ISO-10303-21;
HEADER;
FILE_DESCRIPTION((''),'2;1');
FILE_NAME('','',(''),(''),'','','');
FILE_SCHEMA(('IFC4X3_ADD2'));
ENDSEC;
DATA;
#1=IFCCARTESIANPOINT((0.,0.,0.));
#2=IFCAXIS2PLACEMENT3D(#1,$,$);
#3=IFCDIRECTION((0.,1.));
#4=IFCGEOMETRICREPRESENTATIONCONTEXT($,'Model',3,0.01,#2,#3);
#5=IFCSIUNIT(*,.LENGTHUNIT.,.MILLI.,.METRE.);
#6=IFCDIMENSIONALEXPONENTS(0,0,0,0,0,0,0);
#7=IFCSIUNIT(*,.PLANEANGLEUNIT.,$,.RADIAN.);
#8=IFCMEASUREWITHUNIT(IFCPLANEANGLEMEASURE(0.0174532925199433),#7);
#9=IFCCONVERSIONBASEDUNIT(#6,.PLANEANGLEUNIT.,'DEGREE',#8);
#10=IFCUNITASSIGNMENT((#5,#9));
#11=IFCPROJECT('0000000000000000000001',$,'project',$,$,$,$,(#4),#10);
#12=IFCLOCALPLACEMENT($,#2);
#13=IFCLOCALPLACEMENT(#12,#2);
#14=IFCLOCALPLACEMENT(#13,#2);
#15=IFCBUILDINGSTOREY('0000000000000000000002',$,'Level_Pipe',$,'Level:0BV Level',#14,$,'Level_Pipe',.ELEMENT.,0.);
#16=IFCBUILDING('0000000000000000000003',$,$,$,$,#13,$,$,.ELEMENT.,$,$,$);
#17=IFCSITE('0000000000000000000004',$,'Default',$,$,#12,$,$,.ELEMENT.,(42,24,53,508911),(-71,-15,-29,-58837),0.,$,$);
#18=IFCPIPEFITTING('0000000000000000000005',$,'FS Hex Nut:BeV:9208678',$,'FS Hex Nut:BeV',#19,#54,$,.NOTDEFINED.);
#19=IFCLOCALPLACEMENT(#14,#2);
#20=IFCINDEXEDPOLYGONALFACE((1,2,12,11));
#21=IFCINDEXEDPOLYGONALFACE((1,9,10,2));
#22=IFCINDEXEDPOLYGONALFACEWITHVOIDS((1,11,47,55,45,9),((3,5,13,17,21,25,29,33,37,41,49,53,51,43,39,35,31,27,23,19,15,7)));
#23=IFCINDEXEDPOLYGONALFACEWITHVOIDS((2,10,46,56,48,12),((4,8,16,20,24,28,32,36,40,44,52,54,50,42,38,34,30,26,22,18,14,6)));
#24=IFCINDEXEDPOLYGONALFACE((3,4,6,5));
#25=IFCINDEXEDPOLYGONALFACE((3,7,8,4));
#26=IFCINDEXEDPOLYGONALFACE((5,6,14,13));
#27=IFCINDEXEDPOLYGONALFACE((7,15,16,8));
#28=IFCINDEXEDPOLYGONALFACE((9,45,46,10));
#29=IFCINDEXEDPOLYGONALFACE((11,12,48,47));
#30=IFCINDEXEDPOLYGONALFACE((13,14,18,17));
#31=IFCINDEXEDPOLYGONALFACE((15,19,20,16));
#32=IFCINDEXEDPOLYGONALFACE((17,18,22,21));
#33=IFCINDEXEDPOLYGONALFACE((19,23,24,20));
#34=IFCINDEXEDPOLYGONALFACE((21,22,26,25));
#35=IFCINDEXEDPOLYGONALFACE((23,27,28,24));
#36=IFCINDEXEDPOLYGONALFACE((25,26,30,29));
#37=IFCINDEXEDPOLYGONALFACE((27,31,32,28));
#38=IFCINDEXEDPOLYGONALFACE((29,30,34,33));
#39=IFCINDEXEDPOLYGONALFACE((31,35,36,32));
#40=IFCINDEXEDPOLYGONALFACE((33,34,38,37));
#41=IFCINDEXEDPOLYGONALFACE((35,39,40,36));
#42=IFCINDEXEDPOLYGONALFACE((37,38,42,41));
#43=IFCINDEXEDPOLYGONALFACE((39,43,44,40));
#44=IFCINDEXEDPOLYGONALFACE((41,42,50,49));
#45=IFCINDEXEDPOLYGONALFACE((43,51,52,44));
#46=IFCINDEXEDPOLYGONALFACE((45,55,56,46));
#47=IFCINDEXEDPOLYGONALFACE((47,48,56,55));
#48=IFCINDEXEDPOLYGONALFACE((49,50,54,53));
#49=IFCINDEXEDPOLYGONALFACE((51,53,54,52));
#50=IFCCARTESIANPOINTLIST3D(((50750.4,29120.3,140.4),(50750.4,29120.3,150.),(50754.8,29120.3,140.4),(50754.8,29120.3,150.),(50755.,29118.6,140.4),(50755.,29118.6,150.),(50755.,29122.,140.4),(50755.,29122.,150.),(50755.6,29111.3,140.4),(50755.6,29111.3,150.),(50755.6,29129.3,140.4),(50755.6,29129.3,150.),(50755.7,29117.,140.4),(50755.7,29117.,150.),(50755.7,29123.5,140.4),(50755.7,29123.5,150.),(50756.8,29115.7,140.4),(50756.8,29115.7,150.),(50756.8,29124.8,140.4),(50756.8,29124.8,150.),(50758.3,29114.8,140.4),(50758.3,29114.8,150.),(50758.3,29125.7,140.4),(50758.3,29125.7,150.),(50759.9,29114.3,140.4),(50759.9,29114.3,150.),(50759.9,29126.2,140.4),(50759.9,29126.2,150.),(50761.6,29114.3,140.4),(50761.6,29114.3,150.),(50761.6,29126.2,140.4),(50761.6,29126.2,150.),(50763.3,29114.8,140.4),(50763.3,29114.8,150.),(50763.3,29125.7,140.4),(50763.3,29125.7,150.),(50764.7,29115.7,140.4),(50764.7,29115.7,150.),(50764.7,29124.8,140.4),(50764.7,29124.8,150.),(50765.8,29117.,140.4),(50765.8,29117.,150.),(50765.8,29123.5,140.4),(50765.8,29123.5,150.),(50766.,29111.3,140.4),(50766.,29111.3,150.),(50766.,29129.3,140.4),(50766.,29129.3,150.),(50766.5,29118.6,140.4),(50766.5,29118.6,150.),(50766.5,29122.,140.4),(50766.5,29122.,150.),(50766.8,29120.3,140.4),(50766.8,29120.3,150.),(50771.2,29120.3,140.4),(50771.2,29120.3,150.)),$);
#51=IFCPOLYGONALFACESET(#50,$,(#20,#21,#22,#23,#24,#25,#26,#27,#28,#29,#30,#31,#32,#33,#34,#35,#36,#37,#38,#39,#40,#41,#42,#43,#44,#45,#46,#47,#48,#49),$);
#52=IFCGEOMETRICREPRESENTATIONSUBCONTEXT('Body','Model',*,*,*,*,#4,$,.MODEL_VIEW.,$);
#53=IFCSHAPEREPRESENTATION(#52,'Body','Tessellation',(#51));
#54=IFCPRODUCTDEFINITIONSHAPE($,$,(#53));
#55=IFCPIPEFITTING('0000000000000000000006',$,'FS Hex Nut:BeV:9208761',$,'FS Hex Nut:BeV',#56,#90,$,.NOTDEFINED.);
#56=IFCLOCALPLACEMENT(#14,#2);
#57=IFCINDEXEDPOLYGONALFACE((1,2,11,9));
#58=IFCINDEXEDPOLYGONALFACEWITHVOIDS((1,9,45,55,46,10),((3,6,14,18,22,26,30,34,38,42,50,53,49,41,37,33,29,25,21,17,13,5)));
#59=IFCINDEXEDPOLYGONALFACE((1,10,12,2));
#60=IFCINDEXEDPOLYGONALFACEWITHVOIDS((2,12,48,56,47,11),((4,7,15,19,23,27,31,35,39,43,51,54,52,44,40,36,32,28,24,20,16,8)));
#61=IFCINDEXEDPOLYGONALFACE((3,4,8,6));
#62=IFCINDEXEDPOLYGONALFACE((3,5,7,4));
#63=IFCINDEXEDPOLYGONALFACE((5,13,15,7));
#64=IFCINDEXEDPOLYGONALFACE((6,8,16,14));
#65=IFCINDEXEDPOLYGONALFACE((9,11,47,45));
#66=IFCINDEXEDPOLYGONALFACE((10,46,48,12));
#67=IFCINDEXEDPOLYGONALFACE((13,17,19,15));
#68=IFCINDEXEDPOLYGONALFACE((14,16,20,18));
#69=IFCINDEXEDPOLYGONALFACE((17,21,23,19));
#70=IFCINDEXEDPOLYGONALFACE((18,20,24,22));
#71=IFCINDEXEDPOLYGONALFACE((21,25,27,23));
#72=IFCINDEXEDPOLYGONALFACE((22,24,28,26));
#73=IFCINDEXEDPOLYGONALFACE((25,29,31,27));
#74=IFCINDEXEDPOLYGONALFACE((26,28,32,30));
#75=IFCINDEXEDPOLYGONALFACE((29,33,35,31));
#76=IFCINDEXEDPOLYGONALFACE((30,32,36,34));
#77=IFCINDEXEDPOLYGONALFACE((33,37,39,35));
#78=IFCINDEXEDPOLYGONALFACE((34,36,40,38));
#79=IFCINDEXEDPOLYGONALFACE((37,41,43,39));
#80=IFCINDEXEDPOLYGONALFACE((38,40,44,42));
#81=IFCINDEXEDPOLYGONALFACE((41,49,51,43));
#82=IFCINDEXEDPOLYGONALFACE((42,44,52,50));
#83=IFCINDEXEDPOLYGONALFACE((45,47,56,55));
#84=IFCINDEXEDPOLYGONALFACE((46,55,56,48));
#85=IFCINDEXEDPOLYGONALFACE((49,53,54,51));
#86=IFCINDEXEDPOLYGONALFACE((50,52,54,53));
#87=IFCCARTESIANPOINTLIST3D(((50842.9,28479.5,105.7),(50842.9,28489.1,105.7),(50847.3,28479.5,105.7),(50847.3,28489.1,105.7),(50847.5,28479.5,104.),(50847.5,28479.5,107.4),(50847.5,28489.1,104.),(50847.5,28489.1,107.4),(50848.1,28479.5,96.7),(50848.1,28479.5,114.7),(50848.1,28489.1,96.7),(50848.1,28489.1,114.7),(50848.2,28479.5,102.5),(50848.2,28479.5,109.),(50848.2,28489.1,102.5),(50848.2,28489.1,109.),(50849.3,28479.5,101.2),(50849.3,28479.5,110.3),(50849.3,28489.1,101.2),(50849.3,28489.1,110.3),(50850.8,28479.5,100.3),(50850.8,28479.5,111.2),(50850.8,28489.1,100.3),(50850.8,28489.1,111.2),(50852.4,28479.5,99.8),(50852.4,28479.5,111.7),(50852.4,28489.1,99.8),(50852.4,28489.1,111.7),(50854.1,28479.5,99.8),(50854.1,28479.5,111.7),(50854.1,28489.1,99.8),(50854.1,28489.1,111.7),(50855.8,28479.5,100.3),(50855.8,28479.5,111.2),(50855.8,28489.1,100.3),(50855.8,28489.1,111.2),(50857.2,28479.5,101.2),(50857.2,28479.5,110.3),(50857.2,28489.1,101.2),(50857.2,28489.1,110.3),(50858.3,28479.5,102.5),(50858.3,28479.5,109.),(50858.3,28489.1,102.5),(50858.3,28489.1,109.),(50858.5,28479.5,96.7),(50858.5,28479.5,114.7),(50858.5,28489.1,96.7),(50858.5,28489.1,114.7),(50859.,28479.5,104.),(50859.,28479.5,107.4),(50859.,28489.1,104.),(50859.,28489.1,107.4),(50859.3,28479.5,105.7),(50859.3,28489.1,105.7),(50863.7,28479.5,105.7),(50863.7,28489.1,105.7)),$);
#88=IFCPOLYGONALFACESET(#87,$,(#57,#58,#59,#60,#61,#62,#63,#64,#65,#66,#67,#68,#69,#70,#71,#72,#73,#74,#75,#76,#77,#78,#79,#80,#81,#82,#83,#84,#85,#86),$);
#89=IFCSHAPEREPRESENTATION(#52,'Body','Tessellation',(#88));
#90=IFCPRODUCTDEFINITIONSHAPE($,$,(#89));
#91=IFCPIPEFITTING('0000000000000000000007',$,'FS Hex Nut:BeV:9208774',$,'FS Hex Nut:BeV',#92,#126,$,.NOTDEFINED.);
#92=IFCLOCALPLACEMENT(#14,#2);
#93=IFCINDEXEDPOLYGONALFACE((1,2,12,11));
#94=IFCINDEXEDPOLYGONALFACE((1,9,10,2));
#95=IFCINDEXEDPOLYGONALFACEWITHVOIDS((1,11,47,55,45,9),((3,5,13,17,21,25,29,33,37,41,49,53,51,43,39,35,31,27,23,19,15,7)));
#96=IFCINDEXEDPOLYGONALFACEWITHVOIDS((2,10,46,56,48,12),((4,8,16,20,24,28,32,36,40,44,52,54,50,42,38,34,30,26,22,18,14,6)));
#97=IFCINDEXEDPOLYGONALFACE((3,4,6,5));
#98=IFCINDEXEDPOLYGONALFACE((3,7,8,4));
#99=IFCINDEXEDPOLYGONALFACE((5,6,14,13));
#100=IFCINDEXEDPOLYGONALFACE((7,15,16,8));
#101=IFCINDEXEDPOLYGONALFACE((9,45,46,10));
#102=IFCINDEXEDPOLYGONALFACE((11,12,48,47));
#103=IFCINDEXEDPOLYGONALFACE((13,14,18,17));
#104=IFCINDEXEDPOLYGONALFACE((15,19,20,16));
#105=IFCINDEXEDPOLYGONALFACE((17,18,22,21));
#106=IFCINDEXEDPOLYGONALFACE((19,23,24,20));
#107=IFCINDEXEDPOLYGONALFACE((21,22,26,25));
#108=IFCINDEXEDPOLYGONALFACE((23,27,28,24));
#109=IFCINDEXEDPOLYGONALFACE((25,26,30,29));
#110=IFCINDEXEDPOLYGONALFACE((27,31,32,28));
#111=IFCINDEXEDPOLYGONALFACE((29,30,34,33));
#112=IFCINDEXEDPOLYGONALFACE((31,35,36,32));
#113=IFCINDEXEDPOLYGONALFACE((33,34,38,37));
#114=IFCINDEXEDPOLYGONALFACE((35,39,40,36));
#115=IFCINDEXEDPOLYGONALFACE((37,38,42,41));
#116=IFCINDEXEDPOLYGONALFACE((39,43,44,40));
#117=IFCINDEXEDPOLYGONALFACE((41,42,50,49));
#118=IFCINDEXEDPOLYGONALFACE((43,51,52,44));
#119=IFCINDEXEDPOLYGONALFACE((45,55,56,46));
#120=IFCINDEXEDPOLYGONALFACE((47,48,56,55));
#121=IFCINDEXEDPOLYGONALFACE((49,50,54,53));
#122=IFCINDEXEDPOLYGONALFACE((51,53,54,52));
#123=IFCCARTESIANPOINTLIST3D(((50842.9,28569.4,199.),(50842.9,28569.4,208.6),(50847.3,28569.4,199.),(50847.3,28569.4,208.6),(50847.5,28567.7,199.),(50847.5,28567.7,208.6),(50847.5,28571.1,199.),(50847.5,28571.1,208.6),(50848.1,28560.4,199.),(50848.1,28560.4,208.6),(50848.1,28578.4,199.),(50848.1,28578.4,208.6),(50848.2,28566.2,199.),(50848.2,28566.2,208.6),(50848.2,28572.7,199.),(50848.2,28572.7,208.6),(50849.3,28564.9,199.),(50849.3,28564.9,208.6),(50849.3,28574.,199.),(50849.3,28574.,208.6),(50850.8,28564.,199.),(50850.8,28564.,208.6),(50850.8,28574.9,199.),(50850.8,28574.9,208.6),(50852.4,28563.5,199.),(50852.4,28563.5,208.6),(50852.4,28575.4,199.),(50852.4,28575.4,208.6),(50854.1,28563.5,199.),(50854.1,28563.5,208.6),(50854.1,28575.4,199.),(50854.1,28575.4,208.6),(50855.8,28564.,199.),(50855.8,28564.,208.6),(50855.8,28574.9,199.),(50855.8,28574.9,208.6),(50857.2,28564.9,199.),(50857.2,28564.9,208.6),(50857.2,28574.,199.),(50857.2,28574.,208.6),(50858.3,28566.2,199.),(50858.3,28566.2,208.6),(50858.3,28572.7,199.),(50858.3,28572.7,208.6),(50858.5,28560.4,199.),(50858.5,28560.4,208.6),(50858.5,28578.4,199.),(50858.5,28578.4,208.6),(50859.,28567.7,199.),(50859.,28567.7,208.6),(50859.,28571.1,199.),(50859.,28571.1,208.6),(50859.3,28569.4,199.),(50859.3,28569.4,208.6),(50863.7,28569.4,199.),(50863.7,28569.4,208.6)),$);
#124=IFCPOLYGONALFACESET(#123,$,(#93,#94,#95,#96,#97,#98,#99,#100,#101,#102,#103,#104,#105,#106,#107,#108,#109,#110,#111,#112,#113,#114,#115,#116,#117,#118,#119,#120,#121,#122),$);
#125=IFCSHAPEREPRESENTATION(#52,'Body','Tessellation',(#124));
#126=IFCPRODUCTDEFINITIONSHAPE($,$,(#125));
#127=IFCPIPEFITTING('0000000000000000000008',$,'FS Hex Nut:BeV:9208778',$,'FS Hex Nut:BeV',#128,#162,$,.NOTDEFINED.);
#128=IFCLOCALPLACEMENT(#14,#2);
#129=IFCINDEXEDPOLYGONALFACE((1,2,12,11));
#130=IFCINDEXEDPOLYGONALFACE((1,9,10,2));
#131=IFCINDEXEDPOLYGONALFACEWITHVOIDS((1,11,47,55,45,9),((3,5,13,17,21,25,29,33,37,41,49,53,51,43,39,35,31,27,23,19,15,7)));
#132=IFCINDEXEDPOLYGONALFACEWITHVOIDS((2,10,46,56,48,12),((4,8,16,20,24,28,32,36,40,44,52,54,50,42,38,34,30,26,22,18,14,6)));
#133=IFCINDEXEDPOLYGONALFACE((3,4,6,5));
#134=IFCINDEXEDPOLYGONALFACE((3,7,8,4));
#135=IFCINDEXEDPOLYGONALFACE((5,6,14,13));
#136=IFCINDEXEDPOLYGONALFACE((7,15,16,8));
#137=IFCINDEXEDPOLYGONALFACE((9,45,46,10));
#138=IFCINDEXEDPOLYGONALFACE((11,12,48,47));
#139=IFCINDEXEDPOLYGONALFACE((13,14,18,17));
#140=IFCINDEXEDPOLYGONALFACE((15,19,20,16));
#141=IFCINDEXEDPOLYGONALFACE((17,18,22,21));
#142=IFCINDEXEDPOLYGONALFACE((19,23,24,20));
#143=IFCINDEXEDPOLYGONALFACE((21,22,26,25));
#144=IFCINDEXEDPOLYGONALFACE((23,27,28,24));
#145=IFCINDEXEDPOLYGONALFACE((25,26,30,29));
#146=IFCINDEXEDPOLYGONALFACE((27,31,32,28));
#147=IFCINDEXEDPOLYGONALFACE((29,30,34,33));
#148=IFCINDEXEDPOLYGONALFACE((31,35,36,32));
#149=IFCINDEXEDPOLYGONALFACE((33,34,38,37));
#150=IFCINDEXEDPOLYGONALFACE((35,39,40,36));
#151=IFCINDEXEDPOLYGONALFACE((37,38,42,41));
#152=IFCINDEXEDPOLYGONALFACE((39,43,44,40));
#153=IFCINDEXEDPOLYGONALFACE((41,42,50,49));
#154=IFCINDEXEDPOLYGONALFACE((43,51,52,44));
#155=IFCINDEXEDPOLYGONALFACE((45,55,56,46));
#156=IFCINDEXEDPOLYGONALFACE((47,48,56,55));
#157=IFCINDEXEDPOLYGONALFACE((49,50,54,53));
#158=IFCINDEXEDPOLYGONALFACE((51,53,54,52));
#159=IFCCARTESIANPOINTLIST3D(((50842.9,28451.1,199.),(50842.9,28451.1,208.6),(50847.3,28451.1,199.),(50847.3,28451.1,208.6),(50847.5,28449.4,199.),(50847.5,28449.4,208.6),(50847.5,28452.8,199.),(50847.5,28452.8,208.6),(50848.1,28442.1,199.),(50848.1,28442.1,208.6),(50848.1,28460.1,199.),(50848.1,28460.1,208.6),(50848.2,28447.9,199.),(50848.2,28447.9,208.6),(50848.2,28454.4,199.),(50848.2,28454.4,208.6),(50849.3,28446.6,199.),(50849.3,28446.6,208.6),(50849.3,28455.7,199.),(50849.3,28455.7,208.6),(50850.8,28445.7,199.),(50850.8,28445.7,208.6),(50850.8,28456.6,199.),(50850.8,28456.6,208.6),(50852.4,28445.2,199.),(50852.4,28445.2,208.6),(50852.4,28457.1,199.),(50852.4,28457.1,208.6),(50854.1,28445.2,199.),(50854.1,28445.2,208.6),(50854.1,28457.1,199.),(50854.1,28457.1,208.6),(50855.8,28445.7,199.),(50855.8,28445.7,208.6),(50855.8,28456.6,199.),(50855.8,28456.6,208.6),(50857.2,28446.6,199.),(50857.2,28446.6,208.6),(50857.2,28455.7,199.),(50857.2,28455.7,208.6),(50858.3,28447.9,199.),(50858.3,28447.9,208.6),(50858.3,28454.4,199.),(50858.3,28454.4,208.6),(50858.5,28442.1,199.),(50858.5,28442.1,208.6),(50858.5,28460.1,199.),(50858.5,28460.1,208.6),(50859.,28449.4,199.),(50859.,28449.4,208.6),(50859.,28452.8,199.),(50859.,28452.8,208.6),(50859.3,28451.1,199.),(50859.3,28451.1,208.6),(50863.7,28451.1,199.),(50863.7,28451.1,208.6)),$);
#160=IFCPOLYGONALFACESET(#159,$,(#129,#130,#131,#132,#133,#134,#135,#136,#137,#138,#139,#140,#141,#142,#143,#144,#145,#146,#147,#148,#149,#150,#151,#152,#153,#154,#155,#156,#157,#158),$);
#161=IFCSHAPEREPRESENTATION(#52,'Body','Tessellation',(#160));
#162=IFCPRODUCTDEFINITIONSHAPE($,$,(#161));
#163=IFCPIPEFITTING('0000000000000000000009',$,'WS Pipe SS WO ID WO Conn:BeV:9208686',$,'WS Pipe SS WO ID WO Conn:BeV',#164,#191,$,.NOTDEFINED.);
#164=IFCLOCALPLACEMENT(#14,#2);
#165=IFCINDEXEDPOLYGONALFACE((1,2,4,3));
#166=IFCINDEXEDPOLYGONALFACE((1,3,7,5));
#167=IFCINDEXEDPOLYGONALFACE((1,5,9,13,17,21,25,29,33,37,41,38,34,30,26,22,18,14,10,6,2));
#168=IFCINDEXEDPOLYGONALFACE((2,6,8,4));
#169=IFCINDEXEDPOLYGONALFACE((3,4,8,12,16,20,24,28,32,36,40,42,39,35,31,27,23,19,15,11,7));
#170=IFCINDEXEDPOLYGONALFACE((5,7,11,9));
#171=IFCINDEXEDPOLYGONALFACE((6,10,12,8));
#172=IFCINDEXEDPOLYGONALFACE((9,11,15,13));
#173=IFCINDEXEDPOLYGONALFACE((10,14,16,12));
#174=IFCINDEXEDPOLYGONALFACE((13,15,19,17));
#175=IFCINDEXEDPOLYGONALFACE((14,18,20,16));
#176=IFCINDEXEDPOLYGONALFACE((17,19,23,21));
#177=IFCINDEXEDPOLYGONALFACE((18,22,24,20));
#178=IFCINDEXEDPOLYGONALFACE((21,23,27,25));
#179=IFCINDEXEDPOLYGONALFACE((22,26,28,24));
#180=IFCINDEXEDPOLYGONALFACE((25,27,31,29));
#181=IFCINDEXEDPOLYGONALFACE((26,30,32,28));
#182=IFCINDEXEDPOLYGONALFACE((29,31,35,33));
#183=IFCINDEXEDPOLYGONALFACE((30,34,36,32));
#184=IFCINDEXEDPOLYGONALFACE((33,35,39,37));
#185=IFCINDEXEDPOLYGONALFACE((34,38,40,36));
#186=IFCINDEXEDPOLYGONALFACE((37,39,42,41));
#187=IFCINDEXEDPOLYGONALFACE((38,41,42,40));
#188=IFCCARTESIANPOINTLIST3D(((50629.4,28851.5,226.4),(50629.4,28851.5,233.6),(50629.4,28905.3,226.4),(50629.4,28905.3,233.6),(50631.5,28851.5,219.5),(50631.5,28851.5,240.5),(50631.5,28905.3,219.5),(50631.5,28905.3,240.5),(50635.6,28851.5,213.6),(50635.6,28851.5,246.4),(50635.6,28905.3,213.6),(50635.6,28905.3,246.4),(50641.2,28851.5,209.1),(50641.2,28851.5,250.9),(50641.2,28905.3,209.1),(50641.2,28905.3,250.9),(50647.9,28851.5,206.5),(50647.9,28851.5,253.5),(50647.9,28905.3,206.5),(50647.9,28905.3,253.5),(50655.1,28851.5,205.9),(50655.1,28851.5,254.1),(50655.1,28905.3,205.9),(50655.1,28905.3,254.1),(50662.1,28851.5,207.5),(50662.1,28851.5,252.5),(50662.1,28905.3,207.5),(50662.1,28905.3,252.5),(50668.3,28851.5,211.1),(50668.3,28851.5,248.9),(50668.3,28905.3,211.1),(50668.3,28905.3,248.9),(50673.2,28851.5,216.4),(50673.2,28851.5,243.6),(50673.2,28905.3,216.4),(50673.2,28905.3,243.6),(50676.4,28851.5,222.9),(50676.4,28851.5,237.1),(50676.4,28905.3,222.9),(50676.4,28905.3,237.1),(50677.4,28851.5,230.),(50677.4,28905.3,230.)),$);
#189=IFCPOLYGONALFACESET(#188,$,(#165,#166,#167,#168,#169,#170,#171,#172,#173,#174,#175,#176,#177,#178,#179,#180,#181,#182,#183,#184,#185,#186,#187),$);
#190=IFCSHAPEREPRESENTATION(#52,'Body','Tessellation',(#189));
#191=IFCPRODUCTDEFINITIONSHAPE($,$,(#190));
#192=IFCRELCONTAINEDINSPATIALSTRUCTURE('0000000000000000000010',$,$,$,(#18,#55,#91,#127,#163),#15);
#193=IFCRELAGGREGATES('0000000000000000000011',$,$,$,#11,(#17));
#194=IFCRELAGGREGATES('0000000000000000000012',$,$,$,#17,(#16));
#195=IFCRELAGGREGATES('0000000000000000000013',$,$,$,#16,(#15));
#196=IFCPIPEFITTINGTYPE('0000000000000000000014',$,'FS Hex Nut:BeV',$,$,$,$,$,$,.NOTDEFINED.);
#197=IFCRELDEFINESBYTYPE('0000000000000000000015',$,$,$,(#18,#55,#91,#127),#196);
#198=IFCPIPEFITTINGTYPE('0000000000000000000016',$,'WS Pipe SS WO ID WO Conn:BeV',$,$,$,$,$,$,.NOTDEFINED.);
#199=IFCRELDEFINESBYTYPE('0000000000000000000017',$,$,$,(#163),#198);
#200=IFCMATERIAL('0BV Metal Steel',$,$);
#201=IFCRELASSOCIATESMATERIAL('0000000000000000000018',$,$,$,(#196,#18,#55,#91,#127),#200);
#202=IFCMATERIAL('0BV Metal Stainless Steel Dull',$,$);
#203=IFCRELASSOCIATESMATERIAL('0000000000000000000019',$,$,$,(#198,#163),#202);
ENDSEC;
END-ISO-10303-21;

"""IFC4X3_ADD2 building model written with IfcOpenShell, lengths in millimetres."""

from ifc_helpers import new_model, entity, si_unit, converted_unit, direction, frame, frame_2d, origin, place, context, subcontext, project, spatial, polyline, circle_curve, parameter, trimmed, segment, composite_curve, circle, outline, extrude, source, transform, mapped, material, type_object, type_shapes, element, save


model = new_model("IFC4X3_ADD2")

# Units and contexts
model_context = context("Model", 3, precision=0.01, world=origin(), true_north=direction((0.0, 1.0)))
body_context = subcontext(model_context, "Body", "Model", "MODEL_VIEW")
ifc_project = project(units=[si_unit("LENGTHUNIT", "METRE", prefix="MILLI"), converted_unit("PLANEANGLEUNIT", "DEGREE", entity("IfcPlaneAngleMeasure", 0.0174532925199433), si_unit("PLANEANGLEUNIT", "RADIAN"), dimensions=[0, 0, 0, 0, 0, 0, 0])], contexts=[model_context])

# Site, building, storey
site_placement = place(None, origin())
site = spatial("IfcSite", under=ifc_project, at=site_placement, Name="Default", CompositionType="ELEMENT", RefLatitude=(42, 24, 53, 508911), RefLongitude=(-71, -15, -29, -58837), RefElevation=0.0)
building_placement = place(site_placement, origin())
building = spatial("IfcBuilding", under=site, at=building_placement, CompositionType="ELEMENT")
storey_placement = place(building_placement, origin())
storey = spatial("IfcBuildingStorey", under=building, at=storey_placement, Name="Level_Pipe", ObjectType="Level:0BV Level", LongName="Level_Pipe", CompositionType="ELEMENT", Elevation=0.0)

# Pipe fittings
ifc_material_1 = material(Name="0BV Metal Stainless Steel Dull")
ifc_material_2 = material(Name="0BV Metal Steel")
pipe_fitting_type_1 = type_object("IfcPipeFittingType", Name="FS Hex Nut:BeV", PredefinedType="NOTDEFINED", material=ifc_material_2)
shared_shape_1 = source(origin(), body_context, "Body", "SweptSolid", [
    extrude(outline(polyline([(-5.2, -9.0), (5.2, -9.0), (10.4, 0.0), (5.2, 9.0), (-5.2, 9.0), (-10.4, 0.0), (-5.2, -9.0)]), holes=[composite_curve([segment(trimmed(circle_curve(frame_2d((0.0, 0.0), x_axis=(-0.5, 0.866025)), 6.0), [parameter(0.0)], [parameter(180.0)], True, "PARAMETER"), False, "CONTINUOUS"), segment(trimmed(circle_curve(frame_2d((0.0, 0.0), x_axis=(-0.5, 0.866025)), 6.0), [parameter(180.0)], [parameter(360.0)], True, "PARAMETER"), False, "CONTINUOUS")], self_intersect=False)]), frame((0.0, 10.4, 9.0), z_axis=(1.0, 0.0, 0.0), x_axis=(0.0, -0.5, -0.866025)), (0.0, 0.0, 1.0), 9.6),
])
type_shapes(pipe_fitting_type_1, [shared_shape_1])
for number, where, z_axis, x_axis, name in (
    (1, (50771.2, 29111.3, 150.0), (0.0, 1.0, 0.0), (0.0, 0.0, -1.0), "FS Hex Nut:BeV:9208678"),
    (2, (50863.7, 28479.5, 96.7), (0.0, 0.0, 1.0), (0.0, 1.0, 0.0), "FS Hex Nut:BeV:9208761"),
    (3, (50863.7, 28560.4, 208.6), (0.0, 1.0, 0.0), (0.0, 0.0, -1.0), "FS Hex Nut:BeV:9208774"),
    (4, (50863.7, 28442.1, 208.6), (0.0, 1.0, 0.0), (0.0, 0.0, -1.0), "FS Hex Nut:BeV:9208778"),
):
    element("IfcPipeFitting", number, at=place(storey_placement, frame(where, z_axis=z_axis, x_axis=x_axis)), inside=storey, type_object=pipe_fitting_type_1, material=ifc_material_2, Name=name, ObjectType="FS Hex Nut:BeV", PredefinedType="NOTDEFINED", context=body_context, shape_type="MappedRepresentation", body=[
        mapped(shared_shape_1, transform((0.0, 0.0, 0.0), scale=1.0)),
    ])
pipe_fitting_type_2 = type_object("IfcPipeFittingType", Name="WS Pipe SS WO ID WO Conn:BeV", PredefinedType="NOTDEFINED", material=ifc_material_1)
shared_shape_2 = source(origin(), body_context, "Body", "SweptSolid", [
    extrude(circle(Radius=24.1, at=frame_2d((0.0, 0.0), x_axis=(1.0, 0.0))), frame((-26.9, 0.0, 0.0), z_axis=(1.0, 0.0, 0.0), x_axis=(0.0, 1.0, 0.0)), (0.0, 0.0, 1.0), 53.8),
])
type_shapes(pipe_fitting_type_2, [shared_shape_2])
pipe_fitting_1_placement = place(storey_placement, frame((50653.3, 28878.4, 230.0), z_axis=(0.0, 0.0, 1.0), x_axis=(0.0, -1.0, 0.0)))
element("IfcPipeFitting", 5, at=pipe_fitting_1_placement, inside=storey, type_object=pipe_fitting_type_2, material=ifc_material_1, Name="WS Pipe SS WO ID WO Conn:BeV:9208686", ObjectType="WS Pipe SS WO ID WO Conn:BeV", PredefinedType="NOTDEFINED", context=body_context, shape_type="MappedRepresentation", body=[
    mapped(shared_shape_2, transform((0.0, 0.0, 0.0), scale=1.0)),
])

save(model, "model.ifc")
